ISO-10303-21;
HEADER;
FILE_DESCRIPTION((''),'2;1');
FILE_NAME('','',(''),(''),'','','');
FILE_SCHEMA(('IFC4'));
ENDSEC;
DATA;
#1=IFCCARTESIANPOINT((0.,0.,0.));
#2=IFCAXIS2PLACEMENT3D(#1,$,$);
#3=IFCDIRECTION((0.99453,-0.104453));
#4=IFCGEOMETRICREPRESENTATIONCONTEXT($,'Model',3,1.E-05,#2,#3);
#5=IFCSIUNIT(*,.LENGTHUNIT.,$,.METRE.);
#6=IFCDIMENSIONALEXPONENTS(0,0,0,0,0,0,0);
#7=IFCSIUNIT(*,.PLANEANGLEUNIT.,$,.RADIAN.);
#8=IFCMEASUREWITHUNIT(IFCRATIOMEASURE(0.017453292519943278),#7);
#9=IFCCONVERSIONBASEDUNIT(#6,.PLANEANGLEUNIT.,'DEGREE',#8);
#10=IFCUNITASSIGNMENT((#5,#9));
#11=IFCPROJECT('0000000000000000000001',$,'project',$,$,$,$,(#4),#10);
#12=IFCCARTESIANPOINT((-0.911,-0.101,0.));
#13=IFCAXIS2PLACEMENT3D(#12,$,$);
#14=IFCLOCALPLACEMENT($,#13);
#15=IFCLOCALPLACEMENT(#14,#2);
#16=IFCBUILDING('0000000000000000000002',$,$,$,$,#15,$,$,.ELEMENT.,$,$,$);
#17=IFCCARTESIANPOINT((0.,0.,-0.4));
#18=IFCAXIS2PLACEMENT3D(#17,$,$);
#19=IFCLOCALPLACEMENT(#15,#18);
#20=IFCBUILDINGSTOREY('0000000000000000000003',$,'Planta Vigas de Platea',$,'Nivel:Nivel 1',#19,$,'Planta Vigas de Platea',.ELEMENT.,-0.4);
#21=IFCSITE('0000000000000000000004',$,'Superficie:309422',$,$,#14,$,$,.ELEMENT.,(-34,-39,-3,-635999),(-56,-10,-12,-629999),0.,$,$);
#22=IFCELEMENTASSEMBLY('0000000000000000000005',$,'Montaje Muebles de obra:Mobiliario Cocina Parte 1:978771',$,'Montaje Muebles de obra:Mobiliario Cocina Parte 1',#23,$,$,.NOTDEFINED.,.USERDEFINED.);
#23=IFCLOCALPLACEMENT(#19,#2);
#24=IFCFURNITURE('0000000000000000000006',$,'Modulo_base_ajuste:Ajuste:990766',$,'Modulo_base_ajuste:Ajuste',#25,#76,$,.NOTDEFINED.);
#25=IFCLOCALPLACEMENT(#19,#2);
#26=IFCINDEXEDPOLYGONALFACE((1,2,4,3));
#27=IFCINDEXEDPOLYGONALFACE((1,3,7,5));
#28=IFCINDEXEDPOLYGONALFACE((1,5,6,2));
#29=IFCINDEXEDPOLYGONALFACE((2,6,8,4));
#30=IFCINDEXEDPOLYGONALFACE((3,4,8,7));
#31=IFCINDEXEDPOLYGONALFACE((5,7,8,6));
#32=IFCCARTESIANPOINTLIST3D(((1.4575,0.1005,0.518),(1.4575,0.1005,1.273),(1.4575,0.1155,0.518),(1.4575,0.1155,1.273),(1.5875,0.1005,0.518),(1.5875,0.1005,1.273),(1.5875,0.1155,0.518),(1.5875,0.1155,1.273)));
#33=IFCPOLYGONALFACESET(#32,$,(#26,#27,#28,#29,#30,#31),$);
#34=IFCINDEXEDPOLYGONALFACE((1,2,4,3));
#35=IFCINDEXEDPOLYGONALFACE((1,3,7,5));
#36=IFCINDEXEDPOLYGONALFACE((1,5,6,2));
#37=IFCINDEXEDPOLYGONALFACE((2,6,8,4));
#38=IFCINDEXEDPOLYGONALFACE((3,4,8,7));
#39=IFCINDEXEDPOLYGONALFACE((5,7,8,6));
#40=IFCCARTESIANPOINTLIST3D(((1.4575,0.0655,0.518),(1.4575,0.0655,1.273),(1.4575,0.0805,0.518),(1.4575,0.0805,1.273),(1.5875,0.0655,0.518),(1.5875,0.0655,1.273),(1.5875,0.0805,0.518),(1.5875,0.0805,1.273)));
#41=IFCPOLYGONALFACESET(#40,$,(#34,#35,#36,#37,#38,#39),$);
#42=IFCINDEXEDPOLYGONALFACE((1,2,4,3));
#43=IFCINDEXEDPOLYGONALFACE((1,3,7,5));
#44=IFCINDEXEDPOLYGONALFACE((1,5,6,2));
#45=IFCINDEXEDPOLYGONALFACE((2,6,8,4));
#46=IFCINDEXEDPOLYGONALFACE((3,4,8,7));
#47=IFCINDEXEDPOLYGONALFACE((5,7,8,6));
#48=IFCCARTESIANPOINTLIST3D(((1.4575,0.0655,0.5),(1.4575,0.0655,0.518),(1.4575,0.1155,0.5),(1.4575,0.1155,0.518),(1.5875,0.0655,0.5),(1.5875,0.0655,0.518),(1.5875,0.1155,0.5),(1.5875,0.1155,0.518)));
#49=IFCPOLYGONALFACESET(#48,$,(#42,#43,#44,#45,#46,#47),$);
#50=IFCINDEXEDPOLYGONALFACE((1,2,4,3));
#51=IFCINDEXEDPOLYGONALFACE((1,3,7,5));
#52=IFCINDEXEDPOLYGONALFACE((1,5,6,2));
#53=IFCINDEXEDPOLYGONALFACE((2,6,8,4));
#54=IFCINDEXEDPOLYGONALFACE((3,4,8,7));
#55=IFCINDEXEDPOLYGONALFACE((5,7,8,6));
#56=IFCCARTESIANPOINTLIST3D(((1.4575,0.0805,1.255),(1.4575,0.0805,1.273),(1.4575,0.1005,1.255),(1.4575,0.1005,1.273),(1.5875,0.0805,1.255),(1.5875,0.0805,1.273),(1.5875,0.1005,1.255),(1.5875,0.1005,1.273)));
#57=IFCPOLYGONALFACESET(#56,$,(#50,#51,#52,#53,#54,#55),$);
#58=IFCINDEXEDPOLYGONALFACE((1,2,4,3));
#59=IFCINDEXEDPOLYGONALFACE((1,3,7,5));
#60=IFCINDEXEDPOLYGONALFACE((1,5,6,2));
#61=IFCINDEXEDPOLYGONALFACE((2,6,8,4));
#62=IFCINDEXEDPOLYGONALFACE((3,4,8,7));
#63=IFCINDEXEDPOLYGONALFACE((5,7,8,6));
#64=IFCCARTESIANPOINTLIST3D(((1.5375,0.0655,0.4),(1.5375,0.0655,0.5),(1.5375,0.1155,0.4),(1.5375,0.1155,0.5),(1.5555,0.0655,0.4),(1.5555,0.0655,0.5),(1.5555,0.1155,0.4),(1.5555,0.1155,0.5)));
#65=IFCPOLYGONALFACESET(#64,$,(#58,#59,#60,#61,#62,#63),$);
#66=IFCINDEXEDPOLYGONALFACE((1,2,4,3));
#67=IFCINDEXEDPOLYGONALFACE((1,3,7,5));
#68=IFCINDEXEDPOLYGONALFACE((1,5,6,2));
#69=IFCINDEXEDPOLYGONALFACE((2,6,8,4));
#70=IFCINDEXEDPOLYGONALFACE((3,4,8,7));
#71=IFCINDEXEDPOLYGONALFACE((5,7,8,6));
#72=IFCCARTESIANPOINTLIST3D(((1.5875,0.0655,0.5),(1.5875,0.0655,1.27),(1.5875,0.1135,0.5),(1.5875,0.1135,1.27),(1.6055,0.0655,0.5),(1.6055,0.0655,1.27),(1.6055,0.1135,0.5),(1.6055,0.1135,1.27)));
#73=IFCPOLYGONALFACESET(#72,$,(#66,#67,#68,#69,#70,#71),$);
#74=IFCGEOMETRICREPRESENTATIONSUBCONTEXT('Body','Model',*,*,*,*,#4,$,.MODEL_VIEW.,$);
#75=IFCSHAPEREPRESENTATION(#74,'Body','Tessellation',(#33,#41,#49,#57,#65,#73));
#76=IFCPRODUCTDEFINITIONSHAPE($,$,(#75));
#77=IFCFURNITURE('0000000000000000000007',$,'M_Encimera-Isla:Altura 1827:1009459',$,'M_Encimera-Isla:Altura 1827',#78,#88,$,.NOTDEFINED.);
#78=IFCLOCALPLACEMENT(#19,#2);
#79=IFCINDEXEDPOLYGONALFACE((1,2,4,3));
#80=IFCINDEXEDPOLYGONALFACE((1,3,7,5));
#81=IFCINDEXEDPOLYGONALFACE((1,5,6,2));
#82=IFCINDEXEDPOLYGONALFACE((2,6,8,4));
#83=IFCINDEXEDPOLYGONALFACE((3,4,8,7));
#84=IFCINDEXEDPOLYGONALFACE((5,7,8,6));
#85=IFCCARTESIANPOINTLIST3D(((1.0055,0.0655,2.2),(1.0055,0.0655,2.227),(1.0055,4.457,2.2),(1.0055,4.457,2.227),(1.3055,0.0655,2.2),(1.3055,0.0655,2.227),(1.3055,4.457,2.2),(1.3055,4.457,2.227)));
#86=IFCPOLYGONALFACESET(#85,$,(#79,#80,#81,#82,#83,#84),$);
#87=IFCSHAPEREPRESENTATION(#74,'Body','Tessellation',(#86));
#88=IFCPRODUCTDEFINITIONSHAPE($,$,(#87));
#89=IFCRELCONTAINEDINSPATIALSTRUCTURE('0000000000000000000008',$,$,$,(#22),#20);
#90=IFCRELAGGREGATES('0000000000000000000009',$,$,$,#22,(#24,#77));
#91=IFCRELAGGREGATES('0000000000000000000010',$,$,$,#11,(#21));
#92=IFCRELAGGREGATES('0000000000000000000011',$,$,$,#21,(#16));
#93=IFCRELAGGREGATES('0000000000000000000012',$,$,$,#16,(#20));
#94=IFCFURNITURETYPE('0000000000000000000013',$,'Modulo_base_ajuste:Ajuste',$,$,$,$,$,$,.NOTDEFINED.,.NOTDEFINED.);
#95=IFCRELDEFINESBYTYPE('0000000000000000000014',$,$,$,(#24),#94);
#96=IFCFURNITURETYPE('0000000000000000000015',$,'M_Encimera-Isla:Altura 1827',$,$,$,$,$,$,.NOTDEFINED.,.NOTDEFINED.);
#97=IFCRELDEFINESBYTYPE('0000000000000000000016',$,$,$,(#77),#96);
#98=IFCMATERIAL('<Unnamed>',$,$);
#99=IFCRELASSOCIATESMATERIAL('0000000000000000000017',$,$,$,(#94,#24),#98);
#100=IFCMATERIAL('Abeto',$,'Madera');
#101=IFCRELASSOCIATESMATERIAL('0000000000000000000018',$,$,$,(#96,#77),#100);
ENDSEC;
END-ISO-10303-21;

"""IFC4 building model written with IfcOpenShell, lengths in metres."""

from ifc_helpers import new_model, entity, si_unit, converted_unit, direction, frame, frame_2d, origin, origin_2d_with_axis, place, context, subcontext, project, spatial, rectangle, extrude, source, transform, mapped, material, type_object, type_shapes, element, aggregate, save


model = new_model("IFC4")

# Units and contexts
model_context = context("Model", 3, precision=1e-05, world=origin(), true_north=direction((0.99453, -0.104453)))
body_context = subcontext(model_context, "Body", "Model", "MODEL_VIEW")
ifc_project = project(units=[si_unit("LENGTHUNIT", "METRE"), converted_unit("PLANEANGLEUNIT", "DEGREE", entity("IfcRatioMeasure", 0.017453292519943278), si_unit("PLANEANGLEUNIT", "RADIAN"), dimensions=[0, 0, 0, 0, 0, 0, 0])], contexts=[model_context])

# Site, building, storey
site_placement = place(None, frame((-0.911, -0.101, 0.0)))
site = spatial("IfcSite", under=ifc_project, at=site_placement, Name="Superficie:309422", CompositionType="ELEMENT", RefLatitude=(-34, -39, -3, -635999), RefLongitude=(-56, -10, -12, -629999), RefElevation=0.0)
building_placement = place(site_placement, origin())
building = spatial("IfcBuilding", under=site, at=building_placement, CompositionType="ELEMENT")
storey_placement = place(building_placement, frame((0.0, 0.0, -0.4)))
storey = spatial("IfcBuildingStorey", under=building, at=storey_placement, Name="Planta Vigas de Platea", ObjectType="Nivel:Nivel 1", LongName="Planta Vigas de Platea", CompositionType="ELEMENT", Elevation=-0.4)

# Shared definitions
ifc_material_1 = material(Name="<Unnamed>")

# Element assembly, furniture
assembly_placement = place(storey_placement, origin())
assembly = element("IfcElementAssembly", 1, at=assembly_placement, inside=storey, Name="Montaje Muebles de obra:Mobiliario Cocina Parte 1:978771", ObjectType="Montaje Muebles de obra:Mobiliario Cocina Parte 1", AssemblyPlace="NOTDEFINED", PredefinedType="USERDEFINED")
furniture_type_1 = type_object("IfcFurnitureType", Name="Modulo_base_ajuste:Ajuste", AssemblyPlace="NOTDEFINED", PredefinedType="NOTDEFINED", material=ifc_material_1)
shared_shape_1 = source(origin(), body_context, "Body", "SweptSolid", [
    extrude(rectangle(XDim=0.13, YDim=0.015, at=frame_2d((0.0, 0.0), x_axis=(1.0, 0.0))), frame((0.065, 0.0425, 0.118)), (0.0, 0.0, 1.0), 0.755),
    extrude(rectangle(XDim=0.13, YDim=0.015, at=frame_2d((0.0, 0.0), x_axis=(1.0, 0.0))), frame((0.065, 0.0075, 0.118), z_axis=(0.0, 0.0, 1.0), x_axis=(-1.0, 0.0, 0.0)), (0.0, 0.0, 1.0), 0.755),
    extrude(rectangle(XDim=0.13, YDim=0.05, at=frame_2d((0.0, 0.0), x_axis=(1.0, 0.0))), frame((0.065, 0.025, 0.1)), (0.0, 0.0, 1.0), 0.018),
    extrude(rectangle(XDim=0.13, YDim=0.02, at=frame_2d((0.0, 0.0), x_axis=(1.0, 0.0))), frame((0.065, 0.025, 0.855)), (0.0, 0.0, 1.0), 0.018),
    extrude(rectangle(XDim=0.05, YDim=0.018, at=frame_2d((0.0, 0.0), x_axis=(1.0, 0.0))), frame((0.089, 0.025, 0.0), z_axis=(0.0, 0.0, 1.0), x_axis=(0.0, -1.0, 0.0)), (0.0, 0.0, 1.0), 0.1),
    extrude(rectangle(XDim=0.048, YDim=0.018, at=frame_2d((0.0, 0.0), x_axis=(1.0, 0.0))), frame((0.139, 0.024, 0.1), z_axis=(0.0, 0.0, 1.0), x_axis=(0.0, 1.0, 0.0)), (0.0, 0.0, 1.0), 0.77),
])
type_shapes(furniture_type_1, [shared_shape_1])
furniture_1_placement = place(assembly_placement, frame((1.4575, 0.0655, 0.4)))
furniture_1 = element("IfcFurniture", 2, at=furniture_1_placement, type_object=furniture_type_1, material=ifc_material_1, Name="Modulo_base_ajuste:Ajuste:990766", ObjectType="Modulo_base_ajuste:Ajuste", PredefinedType="NOTDEFINED", context=body_context, shape_type="MappedRepresentation", body=[
    mapped(shared_shape_1, transform((0.0, 0.0, 0.0), scale=1.0)),
])
ifc_material_2 = material(Name="Abeto", Category="Madera")
furniture_type_2 = type_object("IfcFurnitureType", Name="M_Encimera-Isla:Altura 1827", AssemblyPlace="NOTDEFINED", PredefinedType="NOTDEFINED", material=ifc_material_2)
shared_shape_2 = source(origin(), body_context, "Body", "SweptSolid", [
    extrude(rectangle(XDim=4.3915, YDim=0.3, at=origin_2d_with_axis()), frame((2.1958, 0.15, 0.0), z_axis=(0.0, 0.0, 1.0), x_axis=(-1.0, 0.0, 0.0)), (0.0, 0.0, 1.0), 0.027),
])
type_shapes(furniture_type_2, [shared_shape_2])
furniture_2_placement = place(assembly_placement, frame((1.3055, 0.0655, 2.2), z_axis=(0.0, 0.0, 1.0), x_axis=(0.0, 1.0, 0.0)))
furniture_2 = element("IfcFurniture", 3, at=furniture_2_placement, type_object=furniture_type_2, material=ifc_material_2, Name="M_Encimera-Isla:Altura 1827:1009459", ObjectType="M_Encimera-Isla:Altura 1827", PredefinedType="NOTDEFINED", context=body_context, shape_type="MappedRepresentation", body=[
    mapped(shared_shape_2, transform((0.0, 0.0, 0.0), scale=1.0)),
])
aggregate(assembly, [furniture_1, furniture_2])

save(model, "model.ifc")
